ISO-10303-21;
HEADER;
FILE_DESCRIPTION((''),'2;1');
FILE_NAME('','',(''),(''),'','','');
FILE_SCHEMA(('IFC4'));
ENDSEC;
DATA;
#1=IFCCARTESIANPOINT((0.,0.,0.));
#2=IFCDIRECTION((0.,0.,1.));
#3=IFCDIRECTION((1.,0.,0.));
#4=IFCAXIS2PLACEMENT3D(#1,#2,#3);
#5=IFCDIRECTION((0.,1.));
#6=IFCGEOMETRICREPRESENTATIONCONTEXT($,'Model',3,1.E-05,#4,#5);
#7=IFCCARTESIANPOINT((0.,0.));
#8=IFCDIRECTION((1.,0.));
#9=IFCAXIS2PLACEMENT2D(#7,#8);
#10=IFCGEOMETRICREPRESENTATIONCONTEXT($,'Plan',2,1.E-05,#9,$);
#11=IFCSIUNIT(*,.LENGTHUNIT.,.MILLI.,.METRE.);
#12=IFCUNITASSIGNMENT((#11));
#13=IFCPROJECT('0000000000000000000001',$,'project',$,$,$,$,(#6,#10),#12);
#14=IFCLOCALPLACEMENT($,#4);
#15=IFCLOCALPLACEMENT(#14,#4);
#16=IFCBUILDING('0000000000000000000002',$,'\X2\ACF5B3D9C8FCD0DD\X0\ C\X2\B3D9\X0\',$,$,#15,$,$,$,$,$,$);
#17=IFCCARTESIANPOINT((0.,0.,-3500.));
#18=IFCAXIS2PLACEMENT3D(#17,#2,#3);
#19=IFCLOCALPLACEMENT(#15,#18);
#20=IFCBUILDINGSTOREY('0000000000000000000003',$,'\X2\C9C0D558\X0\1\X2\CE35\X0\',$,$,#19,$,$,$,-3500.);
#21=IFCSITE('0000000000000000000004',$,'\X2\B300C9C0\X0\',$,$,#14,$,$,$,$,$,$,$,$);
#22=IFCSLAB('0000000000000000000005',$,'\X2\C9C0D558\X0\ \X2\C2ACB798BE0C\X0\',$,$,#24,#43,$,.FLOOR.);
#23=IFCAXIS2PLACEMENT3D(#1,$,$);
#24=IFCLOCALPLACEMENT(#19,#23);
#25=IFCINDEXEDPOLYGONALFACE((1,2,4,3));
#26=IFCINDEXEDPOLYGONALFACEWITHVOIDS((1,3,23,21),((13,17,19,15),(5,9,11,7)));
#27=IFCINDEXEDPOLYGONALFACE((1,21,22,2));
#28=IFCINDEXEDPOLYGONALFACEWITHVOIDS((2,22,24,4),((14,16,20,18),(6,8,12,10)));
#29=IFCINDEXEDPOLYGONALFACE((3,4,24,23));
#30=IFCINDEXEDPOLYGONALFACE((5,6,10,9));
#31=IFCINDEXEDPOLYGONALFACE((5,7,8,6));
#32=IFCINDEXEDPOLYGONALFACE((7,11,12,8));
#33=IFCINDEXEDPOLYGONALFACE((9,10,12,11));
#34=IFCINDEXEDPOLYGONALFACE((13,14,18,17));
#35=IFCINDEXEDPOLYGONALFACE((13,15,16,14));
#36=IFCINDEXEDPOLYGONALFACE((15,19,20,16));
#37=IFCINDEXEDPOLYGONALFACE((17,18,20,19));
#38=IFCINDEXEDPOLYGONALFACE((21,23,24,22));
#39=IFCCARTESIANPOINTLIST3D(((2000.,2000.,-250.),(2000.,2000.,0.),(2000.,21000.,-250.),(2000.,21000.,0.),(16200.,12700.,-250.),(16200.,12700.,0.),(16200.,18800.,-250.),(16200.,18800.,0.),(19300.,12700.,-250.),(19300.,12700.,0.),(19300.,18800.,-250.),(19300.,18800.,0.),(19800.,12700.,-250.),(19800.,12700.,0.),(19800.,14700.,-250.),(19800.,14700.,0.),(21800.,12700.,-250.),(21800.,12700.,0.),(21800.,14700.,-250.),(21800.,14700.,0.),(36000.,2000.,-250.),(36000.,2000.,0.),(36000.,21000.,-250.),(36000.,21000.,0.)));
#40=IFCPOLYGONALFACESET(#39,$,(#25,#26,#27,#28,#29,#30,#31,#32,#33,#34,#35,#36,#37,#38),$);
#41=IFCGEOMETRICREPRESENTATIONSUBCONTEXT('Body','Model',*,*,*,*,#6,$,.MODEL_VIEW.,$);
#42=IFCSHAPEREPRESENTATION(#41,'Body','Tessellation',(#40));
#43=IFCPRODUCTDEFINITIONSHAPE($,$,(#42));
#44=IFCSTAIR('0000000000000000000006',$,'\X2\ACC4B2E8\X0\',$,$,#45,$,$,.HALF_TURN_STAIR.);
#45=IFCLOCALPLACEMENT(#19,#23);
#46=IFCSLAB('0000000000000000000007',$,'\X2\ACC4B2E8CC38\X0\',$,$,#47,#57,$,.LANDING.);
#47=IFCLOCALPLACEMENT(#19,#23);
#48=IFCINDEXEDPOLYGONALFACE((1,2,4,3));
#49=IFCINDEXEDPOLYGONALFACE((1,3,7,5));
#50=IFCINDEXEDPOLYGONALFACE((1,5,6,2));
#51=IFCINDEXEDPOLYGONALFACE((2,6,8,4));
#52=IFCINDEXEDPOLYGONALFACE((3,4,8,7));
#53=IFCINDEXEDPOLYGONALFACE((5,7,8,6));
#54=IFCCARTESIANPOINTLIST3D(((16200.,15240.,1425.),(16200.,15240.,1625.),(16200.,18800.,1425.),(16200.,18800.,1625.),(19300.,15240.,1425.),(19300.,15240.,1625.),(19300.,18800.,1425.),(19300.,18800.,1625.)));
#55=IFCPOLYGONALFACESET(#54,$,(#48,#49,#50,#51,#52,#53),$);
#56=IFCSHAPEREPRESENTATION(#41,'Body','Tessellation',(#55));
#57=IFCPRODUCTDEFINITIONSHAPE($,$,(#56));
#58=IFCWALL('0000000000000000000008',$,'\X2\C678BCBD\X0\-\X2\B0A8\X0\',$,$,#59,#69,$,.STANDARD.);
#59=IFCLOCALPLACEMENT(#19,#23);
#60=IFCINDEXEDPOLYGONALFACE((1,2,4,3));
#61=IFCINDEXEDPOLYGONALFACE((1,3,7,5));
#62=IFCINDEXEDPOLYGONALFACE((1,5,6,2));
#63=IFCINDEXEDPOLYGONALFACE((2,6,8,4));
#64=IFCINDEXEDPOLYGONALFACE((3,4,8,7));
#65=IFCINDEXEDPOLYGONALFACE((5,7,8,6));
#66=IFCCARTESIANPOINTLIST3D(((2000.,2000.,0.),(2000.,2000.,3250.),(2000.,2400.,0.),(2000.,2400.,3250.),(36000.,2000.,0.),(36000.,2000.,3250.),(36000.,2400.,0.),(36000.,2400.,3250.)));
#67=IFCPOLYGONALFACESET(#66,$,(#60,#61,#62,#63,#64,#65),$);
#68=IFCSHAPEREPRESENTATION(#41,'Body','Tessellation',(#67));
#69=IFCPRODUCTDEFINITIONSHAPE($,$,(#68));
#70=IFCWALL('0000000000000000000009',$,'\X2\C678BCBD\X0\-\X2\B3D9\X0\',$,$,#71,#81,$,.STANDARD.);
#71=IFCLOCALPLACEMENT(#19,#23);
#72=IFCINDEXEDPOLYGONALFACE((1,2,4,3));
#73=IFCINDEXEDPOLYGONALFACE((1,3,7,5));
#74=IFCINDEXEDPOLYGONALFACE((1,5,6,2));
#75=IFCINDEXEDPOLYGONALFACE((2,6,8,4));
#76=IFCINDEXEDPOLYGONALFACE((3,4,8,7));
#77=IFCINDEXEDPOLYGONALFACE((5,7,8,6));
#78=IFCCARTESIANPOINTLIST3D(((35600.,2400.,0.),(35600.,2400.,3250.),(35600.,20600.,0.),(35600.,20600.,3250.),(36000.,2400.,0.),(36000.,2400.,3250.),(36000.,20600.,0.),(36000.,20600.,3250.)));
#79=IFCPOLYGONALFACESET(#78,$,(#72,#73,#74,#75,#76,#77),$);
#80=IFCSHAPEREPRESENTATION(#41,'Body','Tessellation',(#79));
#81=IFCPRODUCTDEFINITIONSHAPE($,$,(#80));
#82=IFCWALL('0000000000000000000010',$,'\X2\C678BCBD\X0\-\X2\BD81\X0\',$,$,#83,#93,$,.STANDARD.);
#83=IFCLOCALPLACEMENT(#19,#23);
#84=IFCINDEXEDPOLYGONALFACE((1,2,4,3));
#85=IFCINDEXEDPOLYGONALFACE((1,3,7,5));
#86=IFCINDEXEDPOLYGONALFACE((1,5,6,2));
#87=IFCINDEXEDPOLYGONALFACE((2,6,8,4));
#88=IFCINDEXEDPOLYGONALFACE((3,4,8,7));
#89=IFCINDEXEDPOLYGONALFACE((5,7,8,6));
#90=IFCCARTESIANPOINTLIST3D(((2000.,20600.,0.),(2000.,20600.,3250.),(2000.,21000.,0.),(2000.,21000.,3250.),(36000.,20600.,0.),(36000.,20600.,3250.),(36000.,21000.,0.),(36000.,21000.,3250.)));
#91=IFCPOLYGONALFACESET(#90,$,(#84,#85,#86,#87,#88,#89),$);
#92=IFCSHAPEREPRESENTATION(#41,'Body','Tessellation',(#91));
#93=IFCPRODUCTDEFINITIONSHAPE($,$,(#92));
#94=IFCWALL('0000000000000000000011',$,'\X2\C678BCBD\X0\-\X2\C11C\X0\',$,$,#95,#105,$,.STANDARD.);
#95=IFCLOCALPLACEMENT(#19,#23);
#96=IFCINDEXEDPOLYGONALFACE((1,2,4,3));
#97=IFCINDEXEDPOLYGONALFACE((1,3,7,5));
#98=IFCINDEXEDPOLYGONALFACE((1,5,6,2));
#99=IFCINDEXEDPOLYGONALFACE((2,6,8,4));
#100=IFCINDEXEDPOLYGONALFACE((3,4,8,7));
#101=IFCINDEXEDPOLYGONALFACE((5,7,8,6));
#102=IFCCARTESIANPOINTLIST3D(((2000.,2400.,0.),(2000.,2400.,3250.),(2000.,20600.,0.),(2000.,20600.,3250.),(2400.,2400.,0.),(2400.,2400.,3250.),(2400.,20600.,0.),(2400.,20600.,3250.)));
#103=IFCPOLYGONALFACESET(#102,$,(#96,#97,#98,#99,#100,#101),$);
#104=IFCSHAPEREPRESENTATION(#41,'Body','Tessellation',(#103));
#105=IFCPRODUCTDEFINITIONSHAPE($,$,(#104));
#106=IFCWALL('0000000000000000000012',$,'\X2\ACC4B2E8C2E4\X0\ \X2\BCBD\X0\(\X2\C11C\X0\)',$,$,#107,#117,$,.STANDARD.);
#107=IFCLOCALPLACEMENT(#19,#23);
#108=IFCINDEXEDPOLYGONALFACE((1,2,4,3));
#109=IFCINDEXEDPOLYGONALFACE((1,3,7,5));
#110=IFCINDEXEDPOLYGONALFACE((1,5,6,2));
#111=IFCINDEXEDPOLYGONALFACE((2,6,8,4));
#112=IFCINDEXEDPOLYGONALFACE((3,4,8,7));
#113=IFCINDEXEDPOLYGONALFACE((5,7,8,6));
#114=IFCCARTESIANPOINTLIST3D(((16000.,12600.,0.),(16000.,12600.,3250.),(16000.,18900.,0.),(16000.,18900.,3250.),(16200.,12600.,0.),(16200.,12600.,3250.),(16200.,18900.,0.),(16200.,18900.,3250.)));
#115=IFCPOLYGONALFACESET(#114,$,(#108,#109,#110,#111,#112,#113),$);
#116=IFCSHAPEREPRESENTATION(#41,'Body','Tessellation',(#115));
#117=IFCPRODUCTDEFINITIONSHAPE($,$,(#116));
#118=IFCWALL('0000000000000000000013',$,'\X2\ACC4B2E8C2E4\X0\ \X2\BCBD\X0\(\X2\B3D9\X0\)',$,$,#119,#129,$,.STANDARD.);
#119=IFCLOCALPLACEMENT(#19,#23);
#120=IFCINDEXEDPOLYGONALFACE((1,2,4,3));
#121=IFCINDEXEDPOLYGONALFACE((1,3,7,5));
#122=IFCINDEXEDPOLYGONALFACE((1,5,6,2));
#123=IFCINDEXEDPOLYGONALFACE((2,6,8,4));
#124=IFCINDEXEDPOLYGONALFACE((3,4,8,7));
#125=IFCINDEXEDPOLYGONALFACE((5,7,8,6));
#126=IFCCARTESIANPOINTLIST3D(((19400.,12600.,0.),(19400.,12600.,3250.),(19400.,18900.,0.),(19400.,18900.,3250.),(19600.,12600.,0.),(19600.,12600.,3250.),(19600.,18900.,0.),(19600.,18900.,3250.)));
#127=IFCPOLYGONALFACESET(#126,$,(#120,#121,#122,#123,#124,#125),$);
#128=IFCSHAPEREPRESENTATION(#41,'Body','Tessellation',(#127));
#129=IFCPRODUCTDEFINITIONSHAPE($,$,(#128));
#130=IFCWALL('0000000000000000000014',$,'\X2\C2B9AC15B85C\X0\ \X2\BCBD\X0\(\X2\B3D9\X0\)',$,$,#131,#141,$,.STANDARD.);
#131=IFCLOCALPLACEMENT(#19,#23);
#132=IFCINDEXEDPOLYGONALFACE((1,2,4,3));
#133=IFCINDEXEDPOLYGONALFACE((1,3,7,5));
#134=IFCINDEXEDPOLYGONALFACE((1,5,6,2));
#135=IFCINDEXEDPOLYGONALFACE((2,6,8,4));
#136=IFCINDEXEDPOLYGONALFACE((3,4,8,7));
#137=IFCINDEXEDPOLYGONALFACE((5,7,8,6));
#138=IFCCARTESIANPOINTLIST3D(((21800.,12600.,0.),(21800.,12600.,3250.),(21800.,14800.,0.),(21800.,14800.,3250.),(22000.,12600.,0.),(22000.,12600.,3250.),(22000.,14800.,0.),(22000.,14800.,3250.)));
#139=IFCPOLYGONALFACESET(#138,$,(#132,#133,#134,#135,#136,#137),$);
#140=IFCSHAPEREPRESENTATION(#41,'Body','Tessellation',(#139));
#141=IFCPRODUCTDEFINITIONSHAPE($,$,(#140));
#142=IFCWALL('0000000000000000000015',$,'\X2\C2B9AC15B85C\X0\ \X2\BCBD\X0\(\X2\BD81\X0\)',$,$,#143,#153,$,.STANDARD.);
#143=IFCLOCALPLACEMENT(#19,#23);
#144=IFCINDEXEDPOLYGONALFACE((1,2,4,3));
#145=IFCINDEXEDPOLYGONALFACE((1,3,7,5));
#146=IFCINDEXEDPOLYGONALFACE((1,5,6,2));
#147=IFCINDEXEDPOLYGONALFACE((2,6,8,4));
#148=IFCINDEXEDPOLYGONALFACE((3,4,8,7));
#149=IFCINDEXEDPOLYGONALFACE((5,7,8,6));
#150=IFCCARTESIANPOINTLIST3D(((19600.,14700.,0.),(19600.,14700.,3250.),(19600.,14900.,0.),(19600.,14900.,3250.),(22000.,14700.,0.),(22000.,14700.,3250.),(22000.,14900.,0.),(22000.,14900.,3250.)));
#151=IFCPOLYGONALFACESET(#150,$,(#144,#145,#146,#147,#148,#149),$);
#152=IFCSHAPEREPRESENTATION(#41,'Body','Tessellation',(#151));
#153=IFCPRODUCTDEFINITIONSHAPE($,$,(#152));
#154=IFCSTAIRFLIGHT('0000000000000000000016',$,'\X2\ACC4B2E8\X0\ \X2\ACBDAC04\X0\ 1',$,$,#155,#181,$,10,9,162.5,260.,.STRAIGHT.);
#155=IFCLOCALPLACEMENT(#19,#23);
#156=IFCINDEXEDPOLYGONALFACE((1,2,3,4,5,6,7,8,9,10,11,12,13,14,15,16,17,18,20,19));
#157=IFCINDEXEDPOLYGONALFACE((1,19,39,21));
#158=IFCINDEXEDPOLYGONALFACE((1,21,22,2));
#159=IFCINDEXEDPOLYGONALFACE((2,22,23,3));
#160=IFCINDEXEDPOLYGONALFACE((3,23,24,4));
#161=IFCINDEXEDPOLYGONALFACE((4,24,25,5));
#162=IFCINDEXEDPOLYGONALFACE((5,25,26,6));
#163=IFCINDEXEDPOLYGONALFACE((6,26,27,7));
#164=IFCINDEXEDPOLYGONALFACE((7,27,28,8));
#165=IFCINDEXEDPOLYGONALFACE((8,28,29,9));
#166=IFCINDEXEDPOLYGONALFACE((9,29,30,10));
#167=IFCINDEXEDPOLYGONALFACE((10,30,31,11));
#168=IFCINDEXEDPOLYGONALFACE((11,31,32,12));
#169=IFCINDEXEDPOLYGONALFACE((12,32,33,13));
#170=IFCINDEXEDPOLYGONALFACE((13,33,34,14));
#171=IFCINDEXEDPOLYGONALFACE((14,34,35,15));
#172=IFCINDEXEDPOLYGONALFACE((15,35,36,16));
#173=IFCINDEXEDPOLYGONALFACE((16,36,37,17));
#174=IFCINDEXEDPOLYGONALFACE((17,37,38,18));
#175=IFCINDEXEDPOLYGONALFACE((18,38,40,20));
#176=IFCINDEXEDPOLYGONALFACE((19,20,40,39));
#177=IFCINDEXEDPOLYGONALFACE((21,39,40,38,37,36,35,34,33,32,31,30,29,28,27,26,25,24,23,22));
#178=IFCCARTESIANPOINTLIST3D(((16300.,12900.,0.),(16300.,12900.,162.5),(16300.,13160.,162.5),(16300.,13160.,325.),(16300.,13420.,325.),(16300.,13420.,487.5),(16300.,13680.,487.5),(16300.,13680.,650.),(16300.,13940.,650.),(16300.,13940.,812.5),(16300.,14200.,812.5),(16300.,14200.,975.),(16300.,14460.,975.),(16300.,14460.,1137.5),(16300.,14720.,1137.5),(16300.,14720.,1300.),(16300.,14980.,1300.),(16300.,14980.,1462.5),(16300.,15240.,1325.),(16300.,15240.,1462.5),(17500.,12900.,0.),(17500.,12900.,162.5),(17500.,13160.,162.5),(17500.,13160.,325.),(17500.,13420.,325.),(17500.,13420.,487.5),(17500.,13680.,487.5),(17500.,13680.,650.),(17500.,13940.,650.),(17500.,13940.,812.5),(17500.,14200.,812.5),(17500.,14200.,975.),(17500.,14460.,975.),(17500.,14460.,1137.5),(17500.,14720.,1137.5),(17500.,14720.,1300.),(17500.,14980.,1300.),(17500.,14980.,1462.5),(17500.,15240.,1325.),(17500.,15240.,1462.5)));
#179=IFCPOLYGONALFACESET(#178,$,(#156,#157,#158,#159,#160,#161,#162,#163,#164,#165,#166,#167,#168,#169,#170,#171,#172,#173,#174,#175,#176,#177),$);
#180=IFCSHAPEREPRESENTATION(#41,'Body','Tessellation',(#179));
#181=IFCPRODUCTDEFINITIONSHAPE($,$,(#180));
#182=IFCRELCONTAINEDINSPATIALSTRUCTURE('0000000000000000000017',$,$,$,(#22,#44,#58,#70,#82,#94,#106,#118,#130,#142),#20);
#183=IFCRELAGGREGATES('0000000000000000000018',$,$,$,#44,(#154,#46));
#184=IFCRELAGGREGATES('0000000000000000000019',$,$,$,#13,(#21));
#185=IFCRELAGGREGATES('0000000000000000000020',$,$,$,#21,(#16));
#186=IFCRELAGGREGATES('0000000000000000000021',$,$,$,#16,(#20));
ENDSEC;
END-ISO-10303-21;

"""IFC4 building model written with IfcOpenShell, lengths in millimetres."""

from ifc_helpers import new_model, si_unit, direction, frame, origin_with_axes, origin_2d_with_axis, place, context, subcontext, project, spatial, polyline, outline, extrude, element, aggregate, save


model = new_model("IFC4")

# Units and contexts
model_context = context("Model", 3, precision=1e-05, world=origin_with_axes(), true_north=direction((0.0, 1.0)))
plan_context = context("Plan", 2, precision=1e-05, world=origin_2d_with_axis())
body_context = subcontext(model_context, "Body", "Model", "MODEL_VIEW")
ifc_project = project(units=[si_unit("LENGTHUNIT", "METRE", prefix="MILLI")], contexts=[model_context, plan_context])

# Site, building, storey
site_placement = place(None, origin_with_axes())
site = spatial("IfcSite", under=ifc_project, at=site_placement, Name="대지")
building_placement = place(site_placement, origin_with_axes())
building = spatial("IfcBuilding", under=site, at=building_placement, Name="공동주택 C동")
storey_placement = place(building_placement, frame((0.0, 0.0, -3500.0), z_axis=(0.0, 0.0, 1.0), x_axis=(1.0, 0.0, 0.0)))
storey = spatial("IfcBuildingStorey", under=building, at=storey_placement, Name="지하1층", Elevation=-3500.0)

# Slab
slab_1_placement = place(storey_placement, origin_with_axes())
element("IfcSlab", 1, at=slab_1_placement, inside=storey, Name="지하 슬래브", PredefinedType="FLOOR", context=body_context, shape_type="SweptSolid", body=[
    extrude(outline(polyline([(2000.0, 2000.0), (36000.0, 2000.0), (36000.0, 21000.0), (2000.0, 21000.0), (2000.0, 2000.0)]), holes=[polyline([(16200.0, 12700.0), (19300.0, 12700.0), (19300.0, 18800.0), (16200.0, 18800.0), (16200.0, 12700.0)]), polyline([(19800.0, 12700.0), (21800.0, 12700.0), (21800.0, 14700.0), (19800.0, 14700.0), (19800.0, 12700.0)])]), frame((0.0, 0.0, -250.0), z_axis=(0.0, 0.0, 1.0), x_axis=(1.0, 0.0, 0.0)), (0.0, 0.0, 1.0), 250.0),
])

# Stair, slab
stair_placement = place(storey_placement, origin_with_axes())
stair = element("IfcStair", 2, at=stair_placement, inside=storey, Name="계단", PredefinedType="HALF_TURN_STAIR")
slab_2_placement = place(stair_placement, origin_with_axes())
slab_2 = element("IfcSlab", 3, at=slab_2_placement, Name="계단참", PredefinedType="LANDING", context=body_context, shape_type="SweptSolid", body=[
    extrude(outline(polyline([(16200.0, 15240.0), (19300.0, 15240.0), (19300.0, 18800.0), (16200.0, 18800.0), (16200.0, 15240.0)])), frame((0.0, 0.0, 1425.0), z_axis=(0.0, 0.0, 1.0), x_axis=(1.0, 0.0, 0.0)), (0.0, 0.0, 1.0), 200.0),
])

# Walls
wall_1_placement = place(storey_placement, origin_with_axes())
element("IfcWall", 4, at=wall_1_placement, inside=storey, Name="외벽-남", PredefinedType="STANDARD", context=body_context, shape_type="SweptSolid", body=[
    extrude(outline(polyline([(2000.0, 2400.0), (36000.0, 2400.0), (36000.0, 2000.0), (2000.0, 2000.0), (2000.0, 2400.0)])), origin_with_axes(), (0.0, 0.0, 1.0), 3250.0),
])
wall_2_placement = place(storey_placement, origin_with_axes())
element("IfcWall", 5, at=wall_2_placement, inside=storey, Name="외벽-동", PredefinedType="STANDARD", context=body_context, shape_type="SweptSolid", body=[
    extrude(outline(polyline([(35600.0, 2400.0), (35600.0, 20600.0), (36000.0, 20600.0), (36000.0, 2400.0), (35600.0, 2400.0)])), origin_with_axes(), (0.0, 0.0, 1.0), 3250.0),
])
wall_3_placement = place(storey_placement, origin_with_axes())
element("IfcWall", 6, at=wall_3_placement, inside=storey, Name="외벽-북", PredefinedType="STANDARD", context=body_context, shape_type="SweptSolid", body=[
    extrude(outline(polyline([(36000.0, 20600.0), (2000.0, 20600.0), (2000.0, 21000.0), (36000.0, 21000.0), (36000.0, 20600.0)])), origin_with_axes(), (0.0, 0.0, 1.0), 3250.0),
])
wall_4_placement = place(storey_placement, origin_with_axes())
element("IfcWall", 7, at=wall_4_placement, inside=storey, Name="외벽-서", PredefinedType="STANDARD", context=body_context, shape_type="SweptSolid", body=[
    extrude(outline(polyline([(2400.0, 20600.0), (2400.0, 2400.0), (2000.0, 2400.0), (2000.0, 20600.0), (2400.0, 20600.0)])), origin_with_axes(), (0.0, 0.0, 1.0), 3250.0),
])
wall_5_placement = place(storey_placement, origin_with_axes())
element("IfcWall", 8, at=wall_5_placement, inside=storey, Name="계단실 벽(서)", PredefinedType="STANDARD", context=body_context, shape_type="SweptSolid", body=[
    extrude(outline(polyline([(16000.0, 12600.0), (16000.0, 18900.0), (16200.0, 18900.0), (16200.0, 12600.0), (16000.0, 12600.0)])), origin_with_axes(), (0.0, 0.0, 1.0), 3250.0),
])
wall_6_placement = place(storey_placement, origin_with_axes())
element("IfcWall", 9, at=wall_6_placement, inside=storey, Name="계단실 벽(동)", PredefinedType="STANDARD", context=body_context, shape_type="SweptSolid", body=[
    extrude(outline(polyline([(19400.0, 12600.0), (19400.0, 18900.0), (19600.0, 18900.0), (19600.0, 12600.0), (19400.0, 12600.0)])), origin_with_axes(), (0.0, 0.0, 1.0), 3250.0),
])
wall_7_placement = place(storey_placement, origin_with_axes())
element("IfcWall", 10, at=wall_7_placement, inside=storey, Name="승강로 벽(동)", PredefinedType="STANDARD", context=body_context, shape_type="SweptSolid", body=[
    extrude(outline(polyline([(21800.0, 12600.0), (21800.0, 14800.0), (22000.0, 14800.0), (22000.0, 12600.0), (21800.0, 12600.0)])), origin_with_axes(), (0.0, 0.0, 1.0), 3250.0),
])
wall_8_placement = place(storey_placement, origin_with_axes())
element("IfcWall", 11, at=wall_8_placement, inside=storey, Name="승강로 벽(북)", PredefinedType="STANDARD", context=body_context, shape_type="SweptSolid", body=[
    extrude(outline(polyline([(19600.0, 14900.0), (22000.0, 14900.0), (22000.0, 14700.0), (19600.0, 14700.0), (19600.0, 14900.0)])), origin_with_axes(), (0.0, 0.0, 1.0), 3250.0),
])

# Stair flight
stair_flight_1_placement = place(stair_placement, origin_with_axes())
stair_flight_1 = element("IfcStairFlight", 12, at=stair_flight_1_placement, Name="계단 경간 1", NumberOfRisers=10, NumberOfTreads=9, PredefinedType="STRAIGHT", RiserHeight=162.5, TreadLength=260.0, context=body_context, shape_type="SweptSolid", body=[
    extrude(outline(polyline([(0.0, 0.0), (0.0, 162.5), (260.0, 162.5), (260.0, 325.0), (520.0, 325.0), (520.0, 487.5), (780.0, 487.5), (780.0, 650.0), (1040.0, 650.0), (1040.0, 812.5), (1300.0, 812.5), (1300.0, 975.0), (1560.0, 975.0), (1560.0, 1137.5), (1820.0, 1137.5), (1820.0, 1300.0), (2080.0, 1300.0), (2080.0, 1462.5), (2340.0, 1462.5), (2340.0, 1625.0), (2340.0, 1325.0), (0.0, 0.0)])), frame((16300.0, 12900.0, 0.0), z_axis=(1.0, 0.0, 0.0), x_axis=(0.0, 1.0, 0.0)), (0.0, 0.0, 1.0), 1200.0),
])

aggregate(stair, [stair_flight_1, slab_2])

save(model, "model.ifc")
